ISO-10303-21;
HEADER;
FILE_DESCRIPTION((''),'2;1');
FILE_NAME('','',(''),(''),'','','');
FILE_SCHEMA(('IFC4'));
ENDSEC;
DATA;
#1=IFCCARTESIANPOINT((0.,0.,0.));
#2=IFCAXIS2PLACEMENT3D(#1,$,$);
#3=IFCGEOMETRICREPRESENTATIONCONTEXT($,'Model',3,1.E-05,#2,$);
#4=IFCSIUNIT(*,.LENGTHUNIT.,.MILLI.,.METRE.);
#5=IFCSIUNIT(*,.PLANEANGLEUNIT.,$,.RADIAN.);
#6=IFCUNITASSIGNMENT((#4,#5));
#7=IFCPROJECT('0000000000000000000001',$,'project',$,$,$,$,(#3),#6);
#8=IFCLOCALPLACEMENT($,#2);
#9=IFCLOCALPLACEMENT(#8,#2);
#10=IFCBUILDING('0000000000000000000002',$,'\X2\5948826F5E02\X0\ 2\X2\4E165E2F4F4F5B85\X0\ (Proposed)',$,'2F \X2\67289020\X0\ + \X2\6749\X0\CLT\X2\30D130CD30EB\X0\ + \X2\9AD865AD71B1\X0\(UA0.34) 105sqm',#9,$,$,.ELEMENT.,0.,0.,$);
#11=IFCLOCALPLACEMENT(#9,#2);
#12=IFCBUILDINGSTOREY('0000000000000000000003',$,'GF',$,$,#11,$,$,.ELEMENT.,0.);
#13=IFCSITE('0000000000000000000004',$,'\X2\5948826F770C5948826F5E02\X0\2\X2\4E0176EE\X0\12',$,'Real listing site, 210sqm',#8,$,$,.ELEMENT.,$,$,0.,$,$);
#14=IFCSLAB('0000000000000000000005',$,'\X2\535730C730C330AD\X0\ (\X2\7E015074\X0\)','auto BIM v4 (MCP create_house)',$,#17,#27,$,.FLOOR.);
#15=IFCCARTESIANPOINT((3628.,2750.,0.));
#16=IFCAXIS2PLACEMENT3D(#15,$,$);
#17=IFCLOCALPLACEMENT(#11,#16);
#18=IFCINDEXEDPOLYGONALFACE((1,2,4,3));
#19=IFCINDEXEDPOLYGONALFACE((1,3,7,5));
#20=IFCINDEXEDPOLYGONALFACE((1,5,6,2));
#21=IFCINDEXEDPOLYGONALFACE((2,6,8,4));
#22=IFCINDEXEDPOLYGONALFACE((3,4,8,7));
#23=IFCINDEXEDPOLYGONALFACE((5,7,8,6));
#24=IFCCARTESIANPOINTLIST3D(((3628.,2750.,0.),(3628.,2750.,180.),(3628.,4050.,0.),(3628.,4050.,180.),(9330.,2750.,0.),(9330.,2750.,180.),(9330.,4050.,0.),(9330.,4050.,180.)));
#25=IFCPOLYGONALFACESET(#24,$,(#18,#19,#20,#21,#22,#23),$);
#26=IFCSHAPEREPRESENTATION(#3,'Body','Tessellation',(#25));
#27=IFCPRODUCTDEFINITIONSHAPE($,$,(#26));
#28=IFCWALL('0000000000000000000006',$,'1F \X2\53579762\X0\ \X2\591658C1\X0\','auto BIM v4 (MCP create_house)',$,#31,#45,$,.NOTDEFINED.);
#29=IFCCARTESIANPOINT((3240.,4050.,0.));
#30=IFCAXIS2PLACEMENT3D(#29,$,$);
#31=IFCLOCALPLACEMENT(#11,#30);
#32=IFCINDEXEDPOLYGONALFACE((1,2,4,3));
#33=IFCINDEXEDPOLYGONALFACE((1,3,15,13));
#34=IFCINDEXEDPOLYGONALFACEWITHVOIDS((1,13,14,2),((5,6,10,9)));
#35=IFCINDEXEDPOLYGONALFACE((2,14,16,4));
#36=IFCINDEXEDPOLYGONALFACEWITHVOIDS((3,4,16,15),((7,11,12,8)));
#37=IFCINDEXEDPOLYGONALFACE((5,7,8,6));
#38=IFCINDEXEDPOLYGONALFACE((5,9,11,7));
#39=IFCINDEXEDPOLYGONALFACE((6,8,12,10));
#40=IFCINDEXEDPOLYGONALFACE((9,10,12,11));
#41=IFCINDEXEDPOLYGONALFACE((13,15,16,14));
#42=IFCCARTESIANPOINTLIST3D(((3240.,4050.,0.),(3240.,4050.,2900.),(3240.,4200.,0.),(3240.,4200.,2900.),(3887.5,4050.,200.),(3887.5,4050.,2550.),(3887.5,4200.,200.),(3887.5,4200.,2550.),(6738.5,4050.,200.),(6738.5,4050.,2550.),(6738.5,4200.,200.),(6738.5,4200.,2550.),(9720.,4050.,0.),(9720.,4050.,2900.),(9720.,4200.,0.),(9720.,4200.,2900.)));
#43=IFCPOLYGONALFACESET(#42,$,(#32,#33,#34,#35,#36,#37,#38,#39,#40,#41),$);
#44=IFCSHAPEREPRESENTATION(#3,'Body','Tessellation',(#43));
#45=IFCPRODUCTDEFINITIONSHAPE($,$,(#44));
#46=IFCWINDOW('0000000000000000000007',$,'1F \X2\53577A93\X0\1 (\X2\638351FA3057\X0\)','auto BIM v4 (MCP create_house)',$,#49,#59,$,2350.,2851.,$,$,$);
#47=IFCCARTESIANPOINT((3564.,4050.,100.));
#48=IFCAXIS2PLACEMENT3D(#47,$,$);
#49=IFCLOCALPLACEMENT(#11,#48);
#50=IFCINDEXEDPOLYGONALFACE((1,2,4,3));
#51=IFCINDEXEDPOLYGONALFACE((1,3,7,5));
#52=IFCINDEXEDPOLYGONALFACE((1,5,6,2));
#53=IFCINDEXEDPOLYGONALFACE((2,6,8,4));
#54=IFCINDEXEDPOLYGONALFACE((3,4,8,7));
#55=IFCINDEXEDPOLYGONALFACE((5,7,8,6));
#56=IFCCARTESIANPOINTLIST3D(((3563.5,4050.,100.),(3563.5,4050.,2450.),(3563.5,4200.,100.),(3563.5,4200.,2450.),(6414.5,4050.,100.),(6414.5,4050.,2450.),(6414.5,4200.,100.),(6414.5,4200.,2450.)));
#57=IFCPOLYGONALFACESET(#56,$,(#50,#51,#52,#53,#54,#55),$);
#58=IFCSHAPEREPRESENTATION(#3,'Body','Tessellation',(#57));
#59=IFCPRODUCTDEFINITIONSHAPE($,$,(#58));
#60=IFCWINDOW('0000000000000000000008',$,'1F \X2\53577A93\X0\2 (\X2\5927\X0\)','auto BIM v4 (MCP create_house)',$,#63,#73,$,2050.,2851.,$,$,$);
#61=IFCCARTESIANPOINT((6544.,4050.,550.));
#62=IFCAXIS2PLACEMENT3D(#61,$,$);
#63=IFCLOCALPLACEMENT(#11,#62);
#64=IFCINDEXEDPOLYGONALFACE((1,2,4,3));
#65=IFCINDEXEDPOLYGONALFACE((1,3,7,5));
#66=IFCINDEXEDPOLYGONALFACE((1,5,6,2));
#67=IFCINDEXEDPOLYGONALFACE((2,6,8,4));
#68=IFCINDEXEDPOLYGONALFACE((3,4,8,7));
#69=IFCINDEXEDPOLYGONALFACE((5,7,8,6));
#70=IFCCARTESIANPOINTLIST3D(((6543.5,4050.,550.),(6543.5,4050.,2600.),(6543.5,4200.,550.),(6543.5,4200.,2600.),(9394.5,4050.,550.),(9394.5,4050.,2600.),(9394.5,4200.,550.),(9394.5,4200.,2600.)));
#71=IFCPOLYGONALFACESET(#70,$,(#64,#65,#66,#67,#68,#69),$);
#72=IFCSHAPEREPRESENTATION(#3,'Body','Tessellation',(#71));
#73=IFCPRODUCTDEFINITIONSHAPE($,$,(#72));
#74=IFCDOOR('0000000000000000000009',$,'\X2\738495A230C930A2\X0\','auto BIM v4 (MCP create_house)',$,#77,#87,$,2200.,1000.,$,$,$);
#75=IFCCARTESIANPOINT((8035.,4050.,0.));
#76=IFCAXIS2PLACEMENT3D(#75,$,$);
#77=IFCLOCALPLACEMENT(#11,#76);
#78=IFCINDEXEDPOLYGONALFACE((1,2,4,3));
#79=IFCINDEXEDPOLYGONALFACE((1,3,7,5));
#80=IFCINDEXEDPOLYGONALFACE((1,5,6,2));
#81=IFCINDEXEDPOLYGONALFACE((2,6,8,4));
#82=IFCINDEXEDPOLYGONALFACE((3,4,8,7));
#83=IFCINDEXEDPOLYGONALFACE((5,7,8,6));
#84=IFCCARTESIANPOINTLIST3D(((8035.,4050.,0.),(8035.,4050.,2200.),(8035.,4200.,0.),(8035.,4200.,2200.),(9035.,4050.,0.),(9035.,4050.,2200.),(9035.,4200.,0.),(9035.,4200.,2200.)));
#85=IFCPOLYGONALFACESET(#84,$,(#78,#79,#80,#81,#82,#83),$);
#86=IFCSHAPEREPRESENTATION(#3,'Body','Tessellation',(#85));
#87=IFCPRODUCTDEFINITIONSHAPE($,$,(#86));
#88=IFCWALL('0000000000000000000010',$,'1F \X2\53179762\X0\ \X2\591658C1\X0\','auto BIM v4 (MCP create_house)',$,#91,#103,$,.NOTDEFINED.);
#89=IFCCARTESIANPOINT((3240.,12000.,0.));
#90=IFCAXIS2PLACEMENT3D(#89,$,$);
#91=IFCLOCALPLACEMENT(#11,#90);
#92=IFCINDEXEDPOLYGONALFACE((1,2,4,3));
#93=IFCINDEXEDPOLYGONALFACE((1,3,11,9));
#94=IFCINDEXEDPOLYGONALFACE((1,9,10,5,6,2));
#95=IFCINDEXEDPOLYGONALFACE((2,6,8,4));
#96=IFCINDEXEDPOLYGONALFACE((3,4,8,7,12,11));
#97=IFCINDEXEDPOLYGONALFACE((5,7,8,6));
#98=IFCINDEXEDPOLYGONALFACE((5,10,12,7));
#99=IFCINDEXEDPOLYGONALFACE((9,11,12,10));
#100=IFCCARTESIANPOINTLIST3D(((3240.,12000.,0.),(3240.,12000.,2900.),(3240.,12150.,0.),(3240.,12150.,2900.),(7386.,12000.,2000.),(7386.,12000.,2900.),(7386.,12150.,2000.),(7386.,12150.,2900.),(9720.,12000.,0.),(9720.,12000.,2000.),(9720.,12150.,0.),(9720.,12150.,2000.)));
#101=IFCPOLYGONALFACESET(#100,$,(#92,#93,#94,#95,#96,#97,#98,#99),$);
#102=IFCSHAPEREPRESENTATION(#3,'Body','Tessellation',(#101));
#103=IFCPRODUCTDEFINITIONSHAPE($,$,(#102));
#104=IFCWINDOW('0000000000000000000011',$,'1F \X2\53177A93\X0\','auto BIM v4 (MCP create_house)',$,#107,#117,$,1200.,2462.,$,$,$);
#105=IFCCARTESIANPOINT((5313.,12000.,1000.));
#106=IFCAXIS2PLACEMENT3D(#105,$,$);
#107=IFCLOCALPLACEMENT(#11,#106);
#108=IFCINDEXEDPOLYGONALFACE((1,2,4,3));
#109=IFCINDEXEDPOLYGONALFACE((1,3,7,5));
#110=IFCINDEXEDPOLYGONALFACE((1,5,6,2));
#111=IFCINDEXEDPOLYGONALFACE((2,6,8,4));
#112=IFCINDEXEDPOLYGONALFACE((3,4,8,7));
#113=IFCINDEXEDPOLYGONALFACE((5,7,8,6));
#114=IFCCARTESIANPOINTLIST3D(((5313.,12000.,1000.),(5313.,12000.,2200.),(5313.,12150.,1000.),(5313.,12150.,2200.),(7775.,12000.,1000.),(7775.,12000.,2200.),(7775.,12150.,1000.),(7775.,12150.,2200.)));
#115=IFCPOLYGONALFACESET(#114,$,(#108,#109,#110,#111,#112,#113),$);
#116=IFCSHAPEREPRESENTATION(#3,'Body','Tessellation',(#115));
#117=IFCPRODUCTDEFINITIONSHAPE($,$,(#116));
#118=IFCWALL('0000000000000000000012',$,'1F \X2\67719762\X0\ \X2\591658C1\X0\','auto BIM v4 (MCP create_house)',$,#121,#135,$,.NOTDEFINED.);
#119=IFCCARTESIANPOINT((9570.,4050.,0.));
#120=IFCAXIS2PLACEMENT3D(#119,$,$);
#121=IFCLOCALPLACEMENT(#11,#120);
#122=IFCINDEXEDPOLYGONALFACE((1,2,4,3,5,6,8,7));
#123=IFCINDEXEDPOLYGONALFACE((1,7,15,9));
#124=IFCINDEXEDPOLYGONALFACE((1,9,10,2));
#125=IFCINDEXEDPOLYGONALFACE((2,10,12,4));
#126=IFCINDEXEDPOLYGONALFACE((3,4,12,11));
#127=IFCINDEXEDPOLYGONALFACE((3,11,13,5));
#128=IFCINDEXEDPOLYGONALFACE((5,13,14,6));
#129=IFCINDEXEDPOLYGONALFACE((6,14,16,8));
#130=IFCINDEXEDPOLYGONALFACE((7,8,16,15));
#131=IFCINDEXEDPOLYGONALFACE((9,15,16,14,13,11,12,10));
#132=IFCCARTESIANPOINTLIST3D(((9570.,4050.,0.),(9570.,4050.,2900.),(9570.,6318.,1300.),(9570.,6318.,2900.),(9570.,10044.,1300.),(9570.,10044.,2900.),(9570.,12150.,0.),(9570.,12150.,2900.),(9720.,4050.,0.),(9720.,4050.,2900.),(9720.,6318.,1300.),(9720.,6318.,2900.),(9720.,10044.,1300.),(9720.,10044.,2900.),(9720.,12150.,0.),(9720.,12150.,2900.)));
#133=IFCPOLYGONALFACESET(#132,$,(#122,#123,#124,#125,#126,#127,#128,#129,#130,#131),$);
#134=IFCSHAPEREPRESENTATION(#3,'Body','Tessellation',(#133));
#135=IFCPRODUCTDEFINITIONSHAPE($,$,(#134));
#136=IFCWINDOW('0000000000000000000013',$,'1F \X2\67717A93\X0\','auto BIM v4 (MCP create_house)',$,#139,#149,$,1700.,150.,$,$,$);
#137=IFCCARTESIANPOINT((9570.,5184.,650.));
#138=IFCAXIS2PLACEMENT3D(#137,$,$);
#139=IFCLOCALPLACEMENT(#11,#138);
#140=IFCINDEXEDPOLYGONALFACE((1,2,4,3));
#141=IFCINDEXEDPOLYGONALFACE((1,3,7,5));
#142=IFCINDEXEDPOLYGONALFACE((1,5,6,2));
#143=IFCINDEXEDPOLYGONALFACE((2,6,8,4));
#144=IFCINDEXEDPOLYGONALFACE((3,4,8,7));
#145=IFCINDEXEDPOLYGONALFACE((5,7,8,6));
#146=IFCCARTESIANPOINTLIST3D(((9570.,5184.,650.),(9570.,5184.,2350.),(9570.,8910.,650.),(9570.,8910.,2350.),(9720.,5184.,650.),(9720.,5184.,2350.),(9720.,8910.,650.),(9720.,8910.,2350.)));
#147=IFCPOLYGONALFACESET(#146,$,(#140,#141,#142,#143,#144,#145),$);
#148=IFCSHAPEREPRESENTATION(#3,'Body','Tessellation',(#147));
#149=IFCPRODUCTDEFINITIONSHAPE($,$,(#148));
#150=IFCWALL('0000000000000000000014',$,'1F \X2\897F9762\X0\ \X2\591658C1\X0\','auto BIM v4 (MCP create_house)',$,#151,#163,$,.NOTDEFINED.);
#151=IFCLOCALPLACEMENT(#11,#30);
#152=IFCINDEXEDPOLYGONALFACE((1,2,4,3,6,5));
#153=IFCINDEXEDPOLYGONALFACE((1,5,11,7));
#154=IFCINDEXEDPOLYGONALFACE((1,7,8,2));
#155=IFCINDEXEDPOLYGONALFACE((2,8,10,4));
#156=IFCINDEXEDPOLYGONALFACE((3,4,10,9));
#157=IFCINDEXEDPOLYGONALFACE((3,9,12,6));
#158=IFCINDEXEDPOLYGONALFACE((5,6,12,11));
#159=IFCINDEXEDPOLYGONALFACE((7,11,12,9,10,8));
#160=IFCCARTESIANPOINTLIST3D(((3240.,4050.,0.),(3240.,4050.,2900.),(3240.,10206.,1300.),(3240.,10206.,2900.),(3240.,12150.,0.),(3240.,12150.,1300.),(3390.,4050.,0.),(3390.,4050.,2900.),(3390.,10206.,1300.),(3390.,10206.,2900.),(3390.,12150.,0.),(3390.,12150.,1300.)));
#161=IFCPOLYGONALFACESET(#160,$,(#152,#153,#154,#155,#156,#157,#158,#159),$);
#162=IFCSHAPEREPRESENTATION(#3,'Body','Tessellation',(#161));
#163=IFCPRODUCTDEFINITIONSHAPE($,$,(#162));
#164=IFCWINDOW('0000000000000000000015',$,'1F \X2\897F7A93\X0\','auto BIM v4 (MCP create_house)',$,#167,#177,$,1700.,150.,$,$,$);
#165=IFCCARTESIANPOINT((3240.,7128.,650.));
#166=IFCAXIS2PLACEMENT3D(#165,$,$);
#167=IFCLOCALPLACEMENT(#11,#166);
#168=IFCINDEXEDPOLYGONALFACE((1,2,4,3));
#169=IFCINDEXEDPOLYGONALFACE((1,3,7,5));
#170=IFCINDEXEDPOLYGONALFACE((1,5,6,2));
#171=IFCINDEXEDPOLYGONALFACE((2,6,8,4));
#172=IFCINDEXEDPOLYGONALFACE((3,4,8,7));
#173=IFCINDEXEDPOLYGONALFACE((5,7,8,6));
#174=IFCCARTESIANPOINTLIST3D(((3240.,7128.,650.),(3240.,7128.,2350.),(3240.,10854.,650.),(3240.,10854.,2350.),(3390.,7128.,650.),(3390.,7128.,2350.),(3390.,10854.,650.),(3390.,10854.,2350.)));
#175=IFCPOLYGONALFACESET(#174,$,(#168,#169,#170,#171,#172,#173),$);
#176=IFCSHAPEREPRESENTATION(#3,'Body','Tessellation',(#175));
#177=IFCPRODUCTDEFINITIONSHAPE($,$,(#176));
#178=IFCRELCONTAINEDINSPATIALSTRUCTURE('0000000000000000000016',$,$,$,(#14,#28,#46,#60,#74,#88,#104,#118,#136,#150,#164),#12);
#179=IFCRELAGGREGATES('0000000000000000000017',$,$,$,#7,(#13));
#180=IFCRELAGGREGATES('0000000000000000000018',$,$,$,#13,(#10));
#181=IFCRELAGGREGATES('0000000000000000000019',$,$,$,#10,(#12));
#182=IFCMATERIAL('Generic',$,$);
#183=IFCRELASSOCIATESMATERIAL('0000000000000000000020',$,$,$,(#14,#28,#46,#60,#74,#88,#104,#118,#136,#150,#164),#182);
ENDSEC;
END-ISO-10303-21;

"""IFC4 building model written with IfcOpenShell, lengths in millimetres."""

from ifc_helpers import new_model, si_unit, frame, frame_2d, origin, place, context, project, spatial, rectangle, extrude, material, element, fill, save


model = new_model("IFC4")

# Units and contexts
model_context = context("Model", 3, precision=1e-05, world=origin())
ifc_project = project(units=[si_unit("LENGTHUNIT", "METRE", prefix="MILLI"), si_unit("PLANEANGLEUNIT", "RADIAN")], contexts=[model_context])

# Site, building, storey
site_placement = place(None, origin())
site = spatial("IfcSite", under=ifc_project, at=site_placement, Name="奈良県奈良市2丁目12", ObjectType="Real listing site, 210sqm", CompositionType="ELEMENT", RefElevation=0.0)
building_placement = place(site_placement, origin())
building = spatial("IfcBuilding", under=site, at=building_placement, Name="奈良市 2世帯住宅 (Proposed)", ObjectType="2F 木造 + 杉CLTパネル + 高断熱(UA0.34) 105sqm", CompositionType="ELEMENT", ElevationOfRefHeight=0.0, ElevationOfTerrain=0.0)
storey_placement = place(building_placement, origin())
storey = spatial("IfcBuildingStorey", under=building, at=storey_placement, Name="GF", CompositionType="ELEMENT", Elevation=0.0)

# Slab
ifc_material = material(Name="Generic")
slab_1_placement = place(storey_placement, frame((3628.0, 2750.0, 0.0)))
element("IfcSlab", 1, at=slab_1_placement, inside=storey, material=ifc_material, Name="南デッキ (縁側)", Description="auto BIM v4 (MCP create_house)", PredefinedType="FLOOR", context=model_context, shape_type="SweptSolid", body=[
    extrude(rectangle(XDim=5702.0, YDim=1300.0, at=frame_2d((2851.0, 650.0))), frame((3628.0, 2750.0, 0.0)), (0.0, 0.0, 1.0), 180.0),
])

# Wall, openings, windows, door
wall_1_placement = place(storey_placement, frame((3240.0, 4050.0, 0.0)))
wall_1 = element("IfcWall", 2, at=wall_1_placement, inside=storey, material=ifc_material, Name="1F 南面 外壁", Description="auto BIM v4 (MCP create_house)", PredefinedType="NOTDEFINED", context=model_context, shape_type="SweptSolid", body=[
    extrude(rectangle(XDim=6480.0, YDim=150.0, at=frame_2d((3240.0, 75.0))), frame((3240.0, 4050.0, 0.0)), (0.0, 0.0, 1.0), 2900.0),
])
opening_1_placement = place(storey_placement, frame((3564.0, 4050.0, 100.0)))
opening_1 = element("IfcOpeningElement", 3, at=opening_1_placement, cuts=wall_1, PredefinedType="NOTDEFINED", context=model_context, shape_type="SweptSolid", body=[
    extrude(rectangle(XDim=2851.0, YDim=150.0, at=frame_2d((1425.0, 75.0))), frame((3564.0, 4050.0, 100.0)), (0.0, 0.0, 1.0), 2350.0),
])
opening_2_placement = place(storey_placement, frame((6544.0, 4050.0, 550.0)))
opening_2 = element("IfcOpeningElement", 4, at=opening_2_placement, cuts=wall_1, PredefinedType="NOTDEFINED", context=model_context, shape_type="SweptSolid", body=[
    extrude(rectangle(XDim=2851.0, YDim=150.0, at=frame_2d((1425.0, 75.0))), frame((6544.0, 4050.0, 550.0)), (0.0, 0.0, 1.0), 2050.0),
])
opening_3_placement = place(storey_placement, frame((8035.0, 4050.0, 0.0)))
opening_3 = element("IfcOpeningElement", 5, at=opening_3_placement, cuts=wall_1, PredefinedType="NOTDEFINED", context=model_context, shape_type="SweptSolid", body=[
    extrude(rectangle(XDim=1000.0, YDim=150.0, at=frame_2d((500.0, 75.0))), frame((8035.0, 4050.0, 0.0)), (0.0, 0.0, 1.0), 2200.0),
])
window_1_placement = place(storey_placement, frame((3564.0, 4050.0, 100.0)))
window_1 = element("IfcWindow", 6, at=window_1_placement, inside=storey, material=ifc_material, Name="1F 南窓1 (掃出し)", Description="auto BIM v4 (MCP create_house)", OverallHeight=2350.0, OverallWidth=2851.0, context=model_context, shape_type="SweptSolid", body=[
    extrude(rectangle(XDim=2851.0, YDim=150.0, at=frame_2d((1425.0, 75.0))), frame((3564.0, 4050.0, 100.0)), (0.0, 0.0, 1.0), 2350.0),
])
fill(opening_1, window_1)
window_2_placement = place(storey_placement, frame((6544.0, 4050.0, 550.0)))
window_2 = element("IfcWindow", 7, at=window_2_placement, inside=storey, material=ifc_material, Name="1F 南窓2 (大)", Description="auto BIM v4 (MCP create_house)", OverallHeight=2050.0, OverallWidth=2851.0, context=model_context, shape_type="SweptSolid", body=[
    extrude(rectangle(XDim=2851.0, YDim=150.0, at=frame_2d((1425.0, 75.0))), frame((6544.0, 4050.0, 550.0)), (0.0, 0.0, 1.0), 2050.0),
])
fill(opening_2, window_2)
door_1_placement = place(storey_placement, frame((8035.0, 4050.0, 0.0)))
door_1 = element("IfcDoor", 8, at=door_1_placement, inside=storey, material=ifc_material, Name="玄関ドア", Description="auto BIM v4 (MCP create_house)", OverallHeight=2200.0, OverallWidth=1000.0, context=model_context, shape_type="SweptSolid", body=[
    extrude(rectangle(XDim=1000.0, YDim=150.0, at=frame_2d((500.0, 75.0))), frame((8035.0, 4050.0, 0.0)), (0.0, 0.0, 1.0), 2200.0),
])
fill(opening_3, door_1)

# Walls, openings, windows
wall_2_placement = place(storey_placement, frame((3240.0, 12000.0, 0.0)))
wall_2 = element("IfcWall", 9, at=wall_2_placement, inside=storey, material=ifc_material, Name="1F 北面 外壁", Description="auto BIM v4 (MCP create_house)", PredefinedType="NOTDEFINED", context=model_context, shape_type="SweptSolid", body=[
    extrude(rectangle(XDim=6480.0, YDim=150.0, at=frame_2d((3240.0, 75.0))), frame((3240.0, 12000.0, 0.0)), (0.0, 0.0, 1.0), 2900.0),
])
opening_4_placement = place(storey_placement, frame((5313.0, 12000.0, 1000.0)))
opening_4 = element("IfcOpeningElement", 10, at=opening_4_placement, cuts=wall_2, PredefinedType="NOTDEFINED", context=model_context, shape_type="SweptSolid", body=[
    extrude(rectangle(XDim=2462.0, YDim=150.0, at=frame_2d((1231.0, 75.0))), frame((5313.0, 12000.0, 1000.0)), (0.0, 0.0, 1.0), 1200.0),
])
window_3_placement = place(storey_placement, frame((5313.0, 12000.0, 1000.0)))
window_3 = element("IfcWindow", 11, at=window_3_placement, inside=storey, material=ifc_material, Name="1F 北窓", Description="auto BIM v4 (MCP create_house)", OverallHeight=1200.0, OverallWidth=2462.0, context=model_context, shape_type="SweptSolid", body=[
    extrude(rectangle(XDim=2462.0, YDim=150.0, at=frame_2d((1231.0, 75.0))), frame((5313.0, 12000.0, 1000.0)), (0.0, 0.0, 1.0), 1200.0),
])
fill(opening_4, window_3)
wall_3_placement = place(storey_placement, frame((9570.0, 4050.0, 0.0)))
wall_3 = element("IfcWall", 12, at=wall_3_placement, inside=storey, material=ifc_material, Name="1F 東面 外壁", Description="auto BIM v4 (MCP create_house)", PredefinedType="NOTDEFINED", context=model_context, shape_type="SweptSolid", body=[
    extrude(rectangle(XDim=150.0, YDim=8100.0, at=frame_2d((75.0, 4050.0))), frame((9570.0, 4050.0, 0.0)), (0.0, 0.0, 1.0), 2900.0),
])
opening_5_placement = place(storey_placement, frame((9570.0, 5184.0, 650.0)))
opening_5 = element("IfcOpeningElement", 13, at=opening_5_placement, cuts=wall_3, PredefinedType="NOTDEFINED", context=model_context, shape_type="SweptSolid", body=[
    extrude(rectangle(XDim=150.0, YDim=3726.0, at=frame_2d((75.0, 1863.0))), frame((9570.0, 5184.0, 650.0)), (0.0, 0.0, 1.0), 1700.0),
])
window_4_placement = place(storey_placement, frame((9570.0, 5184.0, 650.0)))
window_4 = element("IfcWindow", 14, at=window_4_placement, inside=storey, material=ifc_material, Name="1F 東窓", Description="auto BIM v4 (MCP create_house)", OverallHeight=1700.0, OverallWidth=150.0, context=model_context, shape_type="SweptSolid", body=[
    extrude(rectangle(XDim=150.0, YDim=3726.0, at=frame_2d((75.0, 1863.0))), frame((9570.0, 5184.0, 650.0)), (0.0, 0.0, 1.0), 1700.0),
])
fill(opening_5, window_4)
wall_4_placement = place(storey_placement, frame((3240.0, 4050.0, 0.0)))
wall_4 = element("IfcWall", 15, at=wall_4_placement, inside=storey, material=ifc_material, Name="1F 西面 外壁", Description="auto BIM v4 (MCP create_house)", PredefinedType="NOTDEFINED", context=model_context, shape_type="SweptSolid", body=[
    extrude(rectangle(XDim=150.0, YDim=8100.0, at=frame_2d((75.0, 4050.0))), frame((3240.0, 4050.0, 0.0)), (0.0, 0.0, 1.0), 2900.0),
])
opening_6_placement = place(storey_placement, frame((3240.0, 7128.0, 650.0)))
opening_6 = element("IfcOpeningElement", 16, at=opening_6_placement, cuts=wall_4, PredefinedType="NOTDEFINED", context=model_context, shape_type="SweptSolid", body=[
    extrude(rectangle(XDim=150.0, YDim=3726.0, at=frame_2d((75.0, 1863.0))), frame((3240.0, 7128.0, 650.0)), (0.0, 0.0, 1.0), 1700.0),
])
window_5_placement = place(storey_placement, frame((3240.0, 7128.0, 650.0)))
window_5 = element("IfcWindow", 17, at=window_5_placement, inside=storey, material=ifc_material, Name="1F 西窓", Description="auto BIM v4 (MCP create_house)", OverallHeight=1700.0, OverallWidth=150.0, context=model_context, shape_type="SweptSolid", body=[
    extrude(rectangle(XDim=150.0, YDim=3726.0, at=frame_2d((75.0, 1863.0))), frame((3240.0, 7128.0, 650.0)), (0.0, 0.0, 1.0), 1700.0),
])
fill(opening_6, window_5)

save(model, "model.ifc")
